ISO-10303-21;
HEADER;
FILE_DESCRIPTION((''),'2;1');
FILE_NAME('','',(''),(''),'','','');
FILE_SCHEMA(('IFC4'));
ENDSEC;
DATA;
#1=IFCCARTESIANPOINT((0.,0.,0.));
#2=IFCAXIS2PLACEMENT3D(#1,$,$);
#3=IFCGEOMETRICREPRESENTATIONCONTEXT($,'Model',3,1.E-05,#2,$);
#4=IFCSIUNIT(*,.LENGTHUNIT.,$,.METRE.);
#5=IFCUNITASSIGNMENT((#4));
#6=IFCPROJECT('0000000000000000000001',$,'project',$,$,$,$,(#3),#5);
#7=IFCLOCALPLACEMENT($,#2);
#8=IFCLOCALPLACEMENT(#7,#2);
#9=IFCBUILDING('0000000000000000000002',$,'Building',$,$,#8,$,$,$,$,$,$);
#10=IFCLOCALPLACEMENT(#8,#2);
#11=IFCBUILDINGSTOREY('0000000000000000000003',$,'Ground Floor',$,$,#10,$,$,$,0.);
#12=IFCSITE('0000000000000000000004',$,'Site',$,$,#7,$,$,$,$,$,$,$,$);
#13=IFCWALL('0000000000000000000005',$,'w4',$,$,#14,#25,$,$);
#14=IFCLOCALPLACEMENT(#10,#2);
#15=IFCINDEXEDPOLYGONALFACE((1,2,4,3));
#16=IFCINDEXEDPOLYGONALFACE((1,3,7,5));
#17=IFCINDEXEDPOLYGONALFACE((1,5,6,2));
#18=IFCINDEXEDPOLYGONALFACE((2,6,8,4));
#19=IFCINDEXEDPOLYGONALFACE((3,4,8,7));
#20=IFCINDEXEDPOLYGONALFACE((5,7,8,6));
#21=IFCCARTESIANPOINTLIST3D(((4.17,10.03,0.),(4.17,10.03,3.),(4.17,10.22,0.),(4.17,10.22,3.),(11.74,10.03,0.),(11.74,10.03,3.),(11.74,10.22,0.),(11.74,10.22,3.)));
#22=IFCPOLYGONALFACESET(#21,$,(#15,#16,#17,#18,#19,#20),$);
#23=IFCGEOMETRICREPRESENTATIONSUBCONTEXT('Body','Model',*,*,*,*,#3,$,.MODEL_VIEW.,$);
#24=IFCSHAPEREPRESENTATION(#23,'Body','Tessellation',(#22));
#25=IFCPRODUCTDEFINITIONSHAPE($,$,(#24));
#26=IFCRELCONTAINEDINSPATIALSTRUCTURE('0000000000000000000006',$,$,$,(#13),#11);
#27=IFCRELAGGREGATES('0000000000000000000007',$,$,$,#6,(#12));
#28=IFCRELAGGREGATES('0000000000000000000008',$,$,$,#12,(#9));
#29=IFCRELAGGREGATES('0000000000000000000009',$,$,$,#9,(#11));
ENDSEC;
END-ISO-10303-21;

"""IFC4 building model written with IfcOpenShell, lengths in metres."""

from ifc_helpers import new_model, si_unit, frame, origin, place, context, subcontext, project, spatial, polyline, outline, extrude, element, save


model = new_model("IFC4")

# Units and contexts
model_context = context("Model", 3, precision=1e-05, world=origin())
body_context = subcontext(model_context, "Body", "Model", "MODEL_VIEW")
ifc_project = project(units=[si_unit("LENGTHUNIT", "METRE")], contexts=[model_context])

# Site, building, storey
site_placement = place(None, origin())
site = spatial("IfcSite", under=ifc_project, at=site_placement, Name="Site")
building_placement = place(site_placement, origin())
building = spatial("IfcBuilding", under=site, at=building_placement, Name="Building")
storey_placement = place(building_placement, origin())
storey = spatial("IfcBuildingStorey", under=building, at=storey_placement, Name="Ground Floor", Elevation=0.0)

# Wall
wall_1_placement = place(storey_placement, frame((4.17, 10.125, 0.0), x_axis=(1.0, 0.0, 0.0)))
element("IfcWall", 1, at=wall_1_placement, inside=storey, Name="w4", context=body_context, shape_type="SweptSolid", body=[
    extrude(outline(polyline([(0.0, -0.095), (7.57, -0.095), (7.57, 0.095), (0.0, 0.095), (0.0, -0.095)])), origin(), (0.0, 0.0, 1.0), 3.0),
])

save(model, "model.ifc")
